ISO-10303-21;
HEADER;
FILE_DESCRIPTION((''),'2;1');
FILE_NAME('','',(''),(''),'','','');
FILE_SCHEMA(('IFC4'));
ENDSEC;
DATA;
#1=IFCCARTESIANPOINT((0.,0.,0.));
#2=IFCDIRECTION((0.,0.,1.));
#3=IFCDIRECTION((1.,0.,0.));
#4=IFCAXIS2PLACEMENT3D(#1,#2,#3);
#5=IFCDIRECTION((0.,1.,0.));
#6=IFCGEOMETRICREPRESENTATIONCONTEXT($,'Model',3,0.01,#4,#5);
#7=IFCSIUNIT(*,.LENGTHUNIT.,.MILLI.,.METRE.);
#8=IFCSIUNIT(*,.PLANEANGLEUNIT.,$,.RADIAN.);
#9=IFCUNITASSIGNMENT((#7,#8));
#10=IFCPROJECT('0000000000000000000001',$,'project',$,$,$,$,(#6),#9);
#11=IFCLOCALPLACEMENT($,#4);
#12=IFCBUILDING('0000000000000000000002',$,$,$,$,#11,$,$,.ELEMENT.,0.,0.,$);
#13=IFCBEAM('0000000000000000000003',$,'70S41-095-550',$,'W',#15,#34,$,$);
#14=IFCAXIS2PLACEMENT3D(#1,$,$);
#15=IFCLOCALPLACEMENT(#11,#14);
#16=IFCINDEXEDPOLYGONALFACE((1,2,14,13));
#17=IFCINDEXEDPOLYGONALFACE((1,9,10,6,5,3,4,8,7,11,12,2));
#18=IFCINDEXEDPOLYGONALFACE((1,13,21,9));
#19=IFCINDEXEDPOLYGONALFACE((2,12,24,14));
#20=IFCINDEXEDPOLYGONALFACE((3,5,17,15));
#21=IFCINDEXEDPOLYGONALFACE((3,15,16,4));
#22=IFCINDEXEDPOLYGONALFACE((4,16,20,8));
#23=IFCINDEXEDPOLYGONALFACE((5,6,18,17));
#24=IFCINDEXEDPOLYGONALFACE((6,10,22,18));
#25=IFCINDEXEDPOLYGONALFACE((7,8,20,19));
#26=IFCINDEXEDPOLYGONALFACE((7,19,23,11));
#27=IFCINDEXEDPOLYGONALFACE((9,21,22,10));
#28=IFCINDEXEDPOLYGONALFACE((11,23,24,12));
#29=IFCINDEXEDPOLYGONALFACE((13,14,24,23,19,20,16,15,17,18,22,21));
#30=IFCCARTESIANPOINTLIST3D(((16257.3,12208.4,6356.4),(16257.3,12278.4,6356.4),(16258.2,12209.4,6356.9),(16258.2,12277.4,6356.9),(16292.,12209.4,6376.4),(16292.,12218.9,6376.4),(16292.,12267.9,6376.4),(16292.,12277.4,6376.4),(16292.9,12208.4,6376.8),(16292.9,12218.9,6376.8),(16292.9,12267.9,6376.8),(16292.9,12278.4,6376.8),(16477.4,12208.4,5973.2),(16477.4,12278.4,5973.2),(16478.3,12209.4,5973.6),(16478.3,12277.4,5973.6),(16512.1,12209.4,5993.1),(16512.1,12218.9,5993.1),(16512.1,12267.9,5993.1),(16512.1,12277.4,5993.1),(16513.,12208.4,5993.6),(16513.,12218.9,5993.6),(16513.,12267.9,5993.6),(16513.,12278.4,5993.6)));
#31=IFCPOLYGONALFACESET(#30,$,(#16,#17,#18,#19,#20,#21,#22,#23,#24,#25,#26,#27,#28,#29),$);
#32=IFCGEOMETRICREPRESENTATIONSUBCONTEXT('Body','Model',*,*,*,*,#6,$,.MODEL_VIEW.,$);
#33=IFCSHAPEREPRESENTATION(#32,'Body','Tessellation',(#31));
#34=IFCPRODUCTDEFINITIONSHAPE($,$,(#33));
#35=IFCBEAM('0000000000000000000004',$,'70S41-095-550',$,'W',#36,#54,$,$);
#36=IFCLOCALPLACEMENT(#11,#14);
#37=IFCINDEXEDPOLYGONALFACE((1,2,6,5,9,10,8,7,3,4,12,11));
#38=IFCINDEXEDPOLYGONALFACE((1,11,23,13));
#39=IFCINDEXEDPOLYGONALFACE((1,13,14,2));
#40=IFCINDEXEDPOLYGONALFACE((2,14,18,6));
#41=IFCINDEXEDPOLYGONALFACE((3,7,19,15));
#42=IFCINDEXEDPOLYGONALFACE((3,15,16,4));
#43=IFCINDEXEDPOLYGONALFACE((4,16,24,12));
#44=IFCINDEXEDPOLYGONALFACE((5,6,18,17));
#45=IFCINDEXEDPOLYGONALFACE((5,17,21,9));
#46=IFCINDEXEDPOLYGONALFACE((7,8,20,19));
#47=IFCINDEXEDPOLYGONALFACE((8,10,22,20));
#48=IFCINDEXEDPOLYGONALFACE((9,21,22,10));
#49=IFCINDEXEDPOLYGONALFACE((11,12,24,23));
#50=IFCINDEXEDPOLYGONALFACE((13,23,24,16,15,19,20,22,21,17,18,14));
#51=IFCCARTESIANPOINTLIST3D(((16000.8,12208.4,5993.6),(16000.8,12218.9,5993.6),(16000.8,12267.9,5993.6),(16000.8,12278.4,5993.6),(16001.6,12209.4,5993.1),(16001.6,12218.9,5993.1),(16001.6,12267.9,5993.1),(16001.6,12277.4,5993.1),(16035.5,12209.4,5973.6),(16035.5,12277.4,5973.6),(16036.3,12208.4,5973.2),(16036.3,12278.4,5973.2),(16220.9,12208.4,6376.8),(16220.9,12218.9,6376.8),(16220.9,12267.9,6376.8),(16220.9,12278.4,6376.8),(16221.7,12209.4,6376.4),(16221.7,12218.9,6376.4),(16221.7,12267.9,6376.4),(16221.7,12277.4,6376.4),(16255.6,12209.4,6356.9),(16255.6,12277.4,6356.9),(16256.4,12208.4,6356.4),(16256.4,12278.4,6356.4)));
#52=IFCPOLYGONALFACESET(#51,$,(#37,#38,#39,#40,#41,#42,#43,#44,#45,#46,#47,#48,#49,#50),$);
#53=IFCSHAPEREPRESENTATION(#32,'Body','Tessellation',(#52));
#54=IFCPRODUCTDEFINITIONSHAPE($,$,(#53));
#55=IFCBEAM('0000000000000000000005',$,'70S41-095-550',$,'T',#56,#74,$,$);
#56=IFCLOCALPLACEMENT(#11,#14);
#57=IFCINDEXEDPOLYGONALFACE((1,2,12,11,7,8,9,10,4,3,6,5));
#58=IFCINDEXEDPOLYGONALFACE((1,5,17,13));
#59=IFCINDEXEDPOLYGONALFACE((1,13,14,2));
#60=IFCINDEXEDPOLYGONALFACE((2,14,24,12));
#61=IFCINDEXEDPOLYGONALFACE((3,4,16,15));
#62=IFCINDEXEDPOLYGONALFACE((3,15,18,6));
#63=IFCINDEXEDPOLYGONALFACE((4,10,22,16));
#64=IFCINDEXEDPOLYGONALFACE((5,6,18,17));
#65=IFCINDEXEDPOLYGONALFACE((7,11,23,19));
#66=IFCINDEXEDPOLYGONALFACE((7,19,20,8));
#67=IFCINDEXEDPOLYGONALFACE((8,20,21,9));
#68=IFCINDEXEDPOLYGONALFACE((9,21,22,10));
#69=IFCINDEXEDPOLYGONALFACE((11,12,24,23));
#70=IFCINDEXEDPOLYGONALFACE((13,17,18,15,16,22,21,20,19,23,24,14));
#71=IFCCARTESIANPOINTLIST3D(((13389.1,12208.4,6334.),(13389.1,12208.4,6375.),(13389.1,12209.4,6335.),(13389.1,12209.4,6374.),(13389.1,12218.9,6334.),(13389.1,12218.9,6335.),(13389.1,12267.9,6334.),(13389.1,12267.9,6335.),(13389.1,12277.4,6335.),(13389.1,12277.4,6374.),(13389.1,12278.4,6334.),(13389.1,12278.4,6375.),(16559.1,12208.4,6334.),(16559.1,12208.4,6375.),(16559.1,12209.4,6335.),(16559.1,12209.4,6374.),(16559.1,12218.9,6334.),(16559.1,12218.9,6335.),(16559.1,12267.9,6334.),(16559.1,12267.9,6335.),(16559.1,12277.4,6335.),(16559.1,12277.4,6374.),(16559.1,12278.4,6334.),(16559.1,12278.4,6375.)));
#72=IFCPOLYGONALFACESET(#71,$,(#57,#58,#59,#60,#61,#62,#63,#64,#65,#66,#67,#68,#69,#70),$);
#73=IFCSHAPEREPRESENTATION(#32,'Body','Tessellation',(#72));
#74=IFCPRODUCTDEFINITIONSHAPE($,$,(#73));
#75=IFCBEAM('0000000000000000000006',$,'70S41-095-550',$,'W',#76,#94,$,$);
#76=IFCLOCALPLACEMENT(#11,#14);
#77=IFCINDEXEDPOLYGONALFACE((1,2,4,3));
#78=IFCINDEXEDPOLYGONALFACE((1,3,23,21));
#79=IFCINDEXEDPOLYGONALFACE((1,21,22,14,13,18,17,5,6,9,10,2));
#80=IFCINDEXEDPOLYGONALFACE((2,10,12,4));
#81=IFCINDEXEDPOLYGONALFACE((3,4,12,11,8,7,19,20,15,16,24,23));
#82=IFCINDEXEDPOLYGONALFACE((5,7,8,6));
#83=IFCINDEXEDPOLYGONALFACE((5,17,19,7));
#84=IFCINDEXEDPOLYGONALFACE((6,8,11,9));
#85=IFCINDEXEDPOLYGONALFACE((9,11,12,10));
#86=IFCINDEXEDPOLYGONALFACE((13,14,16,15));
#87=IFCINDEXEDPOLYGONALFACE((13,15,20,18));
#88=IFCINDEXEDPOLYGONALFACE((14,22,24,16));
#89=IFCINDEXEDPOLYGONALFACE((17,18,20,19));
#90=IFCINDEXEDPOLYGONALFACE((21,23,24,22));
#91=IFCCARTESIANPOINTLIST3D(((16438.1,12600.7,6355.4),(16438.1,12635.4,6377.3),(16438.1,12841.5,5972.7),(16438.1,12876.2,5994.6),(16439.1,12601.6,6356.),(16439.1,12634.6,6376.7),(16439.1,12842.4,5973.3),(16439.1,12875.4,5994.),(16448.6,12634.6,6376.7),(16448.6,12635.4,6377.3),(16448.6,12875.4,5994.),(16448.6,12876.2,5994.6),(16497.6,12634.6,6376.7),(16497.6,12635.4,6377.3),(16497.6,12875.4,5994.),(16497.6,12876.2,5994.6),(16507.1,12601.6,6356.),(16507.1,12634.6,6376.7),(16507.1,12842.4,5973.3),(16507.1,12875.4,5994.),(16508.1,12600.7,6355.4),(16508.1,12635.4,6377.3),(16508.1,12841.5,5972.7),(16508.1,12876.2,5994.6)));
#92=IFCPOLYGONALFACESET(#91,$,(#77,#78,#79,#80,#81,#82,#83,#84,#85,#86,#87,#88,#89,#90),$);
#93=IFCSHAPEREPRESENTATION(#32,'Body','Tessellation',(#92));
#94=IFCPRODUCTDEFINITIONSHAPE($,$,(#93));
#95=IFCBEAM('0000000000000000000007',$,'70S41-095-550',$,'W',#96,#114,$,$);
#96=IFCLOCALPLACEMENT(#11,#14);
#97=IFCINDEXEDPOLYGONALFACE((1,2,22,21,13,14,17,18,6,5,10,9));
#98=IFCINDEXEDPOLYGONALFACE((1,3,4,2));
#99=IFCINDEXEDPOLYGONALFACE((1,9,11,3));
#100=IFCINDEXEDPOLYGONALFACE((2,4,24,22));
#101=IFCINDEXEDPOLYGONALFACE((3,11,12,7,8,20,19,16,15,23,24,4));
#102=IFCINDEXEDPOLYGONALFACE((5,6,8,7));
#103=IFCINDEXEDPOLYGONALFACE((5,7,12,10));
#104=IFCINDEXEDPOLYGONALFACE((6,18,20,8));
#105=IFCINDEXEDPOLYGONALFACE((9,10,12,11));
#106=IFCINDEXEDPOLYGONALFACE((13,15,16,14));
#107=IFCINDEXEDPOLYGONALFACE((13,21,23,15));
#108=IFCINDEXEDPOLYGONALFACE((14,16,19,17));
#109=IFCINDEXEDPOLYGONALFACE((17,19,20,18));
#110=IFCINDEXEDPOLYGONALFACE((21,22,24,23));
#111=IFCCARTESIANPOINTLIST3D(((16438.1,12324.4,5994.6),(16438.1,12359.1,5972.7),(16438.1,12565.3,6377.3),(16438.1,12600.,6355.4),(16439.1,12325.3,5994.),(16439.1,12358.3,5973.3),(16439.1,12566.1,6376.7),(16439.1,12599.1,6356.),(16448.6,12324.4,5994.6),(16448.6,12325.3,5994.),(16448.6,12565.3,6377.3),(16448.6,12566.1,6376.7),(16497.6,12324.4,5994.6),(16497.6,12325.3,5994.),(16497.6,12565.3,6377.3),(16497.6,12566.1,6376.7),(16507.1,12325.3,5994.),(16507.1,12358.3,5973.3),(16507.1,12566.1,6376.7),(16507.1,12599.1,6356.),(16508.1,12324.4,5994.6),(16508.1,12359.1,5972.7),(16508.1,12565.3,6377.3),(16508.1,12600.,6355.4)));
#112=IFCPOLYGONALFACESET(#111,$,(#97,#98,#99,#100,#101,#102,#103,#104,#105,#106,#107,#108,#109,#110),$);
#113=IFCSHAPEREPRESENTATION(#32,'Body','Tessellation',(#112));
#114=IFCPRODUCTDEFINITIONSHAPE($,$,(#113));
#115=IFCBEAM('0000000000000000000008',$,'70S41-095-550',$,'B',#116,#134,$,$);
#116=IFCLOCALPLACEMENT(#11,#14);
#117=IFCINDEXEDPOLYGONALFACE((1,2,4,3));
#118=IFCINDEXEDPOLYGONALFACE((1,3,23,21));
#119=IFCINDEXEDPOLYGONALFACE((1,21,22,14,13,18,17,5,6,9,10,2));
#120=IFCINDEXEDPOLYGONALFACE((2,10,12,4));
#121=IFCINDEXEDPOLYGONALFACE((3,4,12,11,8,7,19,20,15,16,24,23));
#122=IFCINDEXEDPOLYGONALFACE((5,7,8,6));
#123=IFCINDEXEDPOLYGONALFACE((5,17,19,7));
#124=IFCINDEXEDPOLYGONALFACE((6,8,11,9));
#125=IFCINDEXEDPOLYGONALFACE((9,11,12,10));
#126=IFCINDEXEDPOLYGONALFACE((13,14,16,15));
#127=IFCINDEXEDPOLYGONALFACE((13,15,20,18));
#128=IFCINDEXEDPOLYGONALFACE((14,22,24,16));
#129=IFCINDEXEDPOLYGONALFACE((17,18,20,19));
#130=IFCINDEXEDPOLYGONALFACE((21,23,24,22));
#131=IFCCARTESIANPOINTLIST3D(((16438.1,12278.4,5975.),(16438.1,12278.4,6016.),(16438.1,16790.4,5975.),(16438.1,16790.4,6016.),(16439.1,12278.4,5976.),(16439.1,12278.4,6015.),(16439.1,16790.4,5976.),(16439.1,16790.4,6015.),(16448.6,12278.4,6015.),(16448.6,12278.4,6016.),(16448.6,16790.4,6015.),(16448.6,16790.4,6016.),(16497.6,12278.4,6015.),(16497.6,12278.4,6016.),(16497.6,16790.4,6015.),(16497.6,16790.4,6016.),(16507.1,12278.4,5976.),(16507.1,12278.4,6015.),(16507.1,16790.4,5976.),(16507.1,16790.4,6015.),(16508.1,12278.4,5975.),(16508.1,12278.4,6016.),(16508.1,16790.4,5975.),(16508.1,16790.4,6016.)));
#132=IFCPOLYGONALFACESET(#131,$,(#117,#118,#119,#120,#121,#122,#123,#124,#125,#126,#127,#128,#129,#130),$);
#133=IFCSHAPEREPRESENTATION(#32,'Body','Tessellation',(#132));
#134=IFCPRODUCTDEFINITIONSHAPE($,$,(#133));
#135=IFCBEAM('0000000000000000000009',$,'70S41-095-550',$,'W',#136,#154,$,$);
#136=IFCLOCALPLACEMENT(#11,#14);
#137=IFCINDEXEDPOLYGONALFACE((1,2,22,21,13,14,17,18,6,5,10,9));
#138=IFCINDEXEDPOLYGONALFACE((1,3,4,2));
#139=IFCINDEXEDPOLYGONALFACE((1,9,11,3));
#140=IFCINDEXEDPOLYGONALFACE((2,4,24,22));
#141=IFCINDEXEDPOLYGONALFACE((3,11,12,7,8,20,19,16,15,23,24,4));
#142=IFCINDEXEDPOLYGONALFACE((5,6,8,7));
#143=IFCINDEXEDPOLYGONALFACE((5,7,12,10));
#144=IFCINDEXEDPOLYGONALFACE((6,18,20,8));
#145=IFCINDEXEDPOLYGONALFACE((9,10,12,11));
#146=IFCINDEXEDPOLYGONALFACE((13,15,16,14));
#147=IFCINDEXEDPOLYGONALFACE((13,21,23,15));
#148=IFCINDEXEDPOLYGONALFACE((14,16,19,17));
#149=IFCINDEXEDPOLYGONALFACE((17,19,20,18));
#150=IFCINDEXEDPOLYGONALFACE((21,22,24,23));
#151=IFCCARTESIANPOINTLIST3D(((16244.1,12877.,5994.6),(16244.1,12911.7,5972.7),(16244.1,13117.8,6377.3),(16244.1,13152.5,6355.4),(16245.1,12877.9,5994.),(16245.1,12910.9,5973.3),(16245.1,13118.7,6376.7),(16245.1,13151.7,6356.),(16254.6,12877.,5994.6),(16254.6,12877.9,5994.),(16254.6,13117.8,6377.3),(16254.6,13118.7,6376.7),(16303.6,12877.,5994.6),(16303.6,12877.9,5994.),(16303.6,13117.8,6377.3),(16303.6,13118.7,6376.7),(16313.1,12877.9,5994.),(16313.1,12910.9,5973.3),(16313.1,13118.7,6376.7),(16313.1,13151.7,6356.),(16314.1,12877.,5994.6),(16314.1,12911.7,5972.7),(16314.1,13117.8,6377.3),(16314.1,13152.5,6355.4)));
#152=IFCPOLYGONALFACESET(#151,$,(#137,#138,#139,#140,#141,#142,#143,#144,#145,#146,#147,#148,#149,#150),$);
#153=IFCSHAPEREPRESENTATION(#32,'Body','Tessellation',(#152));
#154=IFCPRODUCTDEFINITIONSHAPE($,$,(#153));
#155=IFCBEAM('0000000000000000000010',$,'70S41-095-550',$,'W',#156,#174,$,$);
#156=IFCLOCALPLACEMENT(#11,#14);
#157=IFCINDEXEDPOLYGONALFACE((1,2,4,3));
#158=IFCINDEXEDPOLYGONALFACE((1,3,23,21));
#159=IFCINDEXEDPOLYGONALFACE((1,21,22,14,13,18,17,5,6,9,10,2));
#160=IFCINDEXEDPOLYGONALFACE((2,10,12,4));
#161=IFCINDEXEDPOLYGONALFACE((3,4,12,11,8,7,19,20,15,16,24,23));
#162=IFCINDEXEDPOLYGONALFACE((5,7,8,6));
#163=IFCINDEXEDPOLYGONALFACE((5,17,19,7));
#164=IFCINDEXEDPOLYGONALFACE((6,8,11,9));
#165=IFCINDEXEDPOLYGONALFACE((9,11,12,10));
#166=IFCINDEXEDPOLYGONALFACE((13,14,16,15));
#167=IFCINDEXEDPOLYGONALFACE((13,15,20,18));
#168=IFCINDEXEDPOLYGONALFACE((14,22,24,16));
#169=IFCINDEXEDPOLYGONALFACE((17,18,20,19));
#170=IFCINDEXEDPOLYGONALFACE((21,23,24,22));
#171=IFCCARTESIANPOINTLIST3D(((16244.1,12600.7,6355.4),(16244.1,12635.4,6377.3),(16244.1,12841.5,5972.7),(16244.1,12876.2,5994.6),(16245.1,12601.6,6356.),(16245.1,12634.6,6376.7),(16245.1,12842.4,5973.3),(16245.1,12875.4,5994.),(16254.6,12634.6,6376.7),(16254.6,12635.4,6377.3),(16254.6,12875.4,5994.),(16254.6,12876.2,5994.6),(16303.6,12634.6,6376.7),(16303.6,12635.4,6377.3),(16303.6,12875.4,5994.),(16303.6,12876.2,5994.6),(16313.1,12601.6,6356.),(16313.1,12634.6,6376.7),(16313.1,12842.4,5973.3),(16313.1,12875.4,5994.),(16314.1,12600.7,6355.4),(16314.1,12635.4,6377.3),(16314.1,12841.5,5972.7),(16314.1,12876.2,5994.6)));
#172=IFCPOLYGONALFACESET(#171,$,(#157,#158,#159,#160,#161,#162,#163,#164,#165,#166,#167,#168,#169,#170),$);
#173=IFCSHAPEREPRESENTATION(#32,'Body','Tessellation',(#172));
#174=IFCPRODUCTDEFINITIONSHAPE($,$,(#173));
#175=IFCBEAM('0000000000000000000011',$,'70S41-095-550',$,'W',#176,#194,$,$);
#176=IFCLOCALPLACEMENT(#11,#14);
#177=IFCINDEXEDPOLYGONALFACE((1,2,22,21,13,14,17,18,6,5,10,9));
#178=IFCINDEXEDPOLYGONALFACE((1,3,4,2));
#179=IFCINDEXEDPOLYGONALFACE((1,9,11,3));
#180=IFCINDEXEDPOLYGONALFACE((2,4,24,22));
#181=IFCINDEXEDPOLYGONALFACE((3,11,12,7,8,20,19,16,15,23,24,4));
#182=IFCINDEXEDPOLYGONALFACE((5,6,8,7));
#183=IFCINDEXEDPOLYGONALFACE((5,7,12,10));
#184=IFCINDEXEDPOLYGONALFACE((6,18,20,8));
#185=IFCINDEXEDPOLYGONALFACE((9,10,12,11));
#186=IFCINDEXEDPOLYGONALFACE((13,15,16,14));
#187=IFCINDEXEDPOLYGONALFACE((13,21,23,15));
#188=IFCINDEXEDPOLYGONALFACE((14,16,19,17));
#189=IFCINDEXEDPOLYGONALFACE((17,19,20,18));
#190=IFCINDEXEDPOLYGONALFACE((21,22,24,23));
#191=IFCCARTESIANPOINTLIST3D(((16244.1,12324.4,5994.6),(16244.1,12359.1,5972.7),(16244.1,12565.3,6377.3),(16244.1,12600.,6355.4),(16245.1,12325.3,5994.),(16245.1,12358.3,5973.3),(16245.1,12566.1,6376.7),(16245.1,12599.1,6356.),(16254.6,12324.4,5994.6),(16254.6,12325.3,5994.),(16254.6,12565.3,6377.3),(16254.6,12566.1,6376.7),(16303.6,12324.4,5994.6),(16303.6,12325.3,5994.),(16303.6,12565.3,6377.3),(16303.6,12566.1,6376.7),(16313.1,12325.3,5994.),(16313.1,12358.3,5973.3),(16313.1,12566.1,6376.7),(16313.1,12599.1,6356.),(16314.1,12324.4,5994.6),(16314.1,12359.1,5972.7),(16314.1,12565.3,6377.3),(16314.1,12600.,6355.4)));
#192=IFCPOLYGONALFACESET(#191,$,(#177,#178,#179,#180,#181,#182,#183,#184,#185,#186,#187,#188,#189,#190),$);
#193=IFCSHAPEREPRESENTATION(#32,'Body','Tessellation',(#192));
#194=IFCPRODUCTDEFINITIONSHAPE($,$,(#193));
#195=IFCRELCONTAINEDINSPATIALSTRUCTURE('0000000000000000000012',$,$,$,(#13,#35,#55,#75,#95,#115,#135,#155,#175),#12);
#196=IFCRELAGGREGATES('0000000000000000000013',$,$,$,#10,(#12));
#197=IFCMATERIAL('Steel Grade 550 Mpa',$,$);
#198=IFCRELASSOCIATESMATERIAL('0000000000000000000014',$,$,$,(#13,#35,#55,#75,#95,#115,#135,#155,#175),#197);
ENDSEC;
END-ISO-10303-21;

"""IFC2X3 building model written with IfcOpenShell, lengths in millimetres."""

from ifc_helpers import new_model, si_unit, direction, frame, origin, origin_with_axes, origin_2d_with_axis, place, context, subcontext, project, spatial, c_section, extrude, source, transform, mapped, material, element, save


model = new_model("IFC2X3")

# Units and contexts
model_context = context("Model", 3, precision=0.01, world=origin_with_axes(), true_north=direction((0.0, 1.0, 0.0)))
body_context = subcontext(model_context, "Body", "Model", "MODEL_VIEW")
ifc_project = project(units=[si_unit("LENGTHUNIT", "METRE", prefix="MILLI"), si_unit("PLANEANGLEUNIT", "RADIAN")], contexts=[model_context])

# Building
building_placement = place(None, origin_with_axes())
building = spatial("IfcBuilding", under=ifc_project, at=building_placement, CompositionType="ELEMENT", ElevationOfRefHeight=0.0, ElevationOfTerrain=0.0)

# Shared definitions
ifc_material = material(Name="Steel Grade 550 Mpa")

# Beams
shared_shape_1 = source(origin(), body_context, "Body", "SweptSolid", [
    extrude(c_section(Depth=70.0, Width=41.0, WallThickness=1.0, Girth=10.5, at=origin_2d_with_axis()), origin_with_axes(), (0.0, 0.0, 1.0), 442.0),
])
beam_1_placement = place(None, frame((16275.1, 12243.4, 6366.6), z_axis=(0.497993, 0.0, -0.867181), x_axis=(0.867181, 0.0, 0.497993)))
element("IfcBeam", 1, at=beam_1_placement, inside=building, material=ifc_material, Name="70S41-095-550", ObjectType="W", context=body_context, shape_type="MappedRepresentation", body=[
    mapped(shared_shape_1, transform((0.0, 0.0, 0.0), scale=1.0)),
])
shared_shape_2 = source(origin(), body_context, "Body", "SweptSolid", [
    extrude(c_section(Depth=70.0, Width=41.0, WallThickness=1.0, Girth=10.5, at=origin_2d_with_axis()), origin_with_axes(), (0.0, 0.0, 1.0), 442.0),
])
beam_2_placement = place(None, frame((16018.5, 12243.4, 5983.4), z_axis=(0.497993, 0.0, 0.867181), x_axis=(-0.867181, 0.0, 0.497993)))
element("IfcBeam", 2, at=beam_2_placement, inside=building, material=ifc_material, Name="70S41-095-550", ObjectType="W", context=body_context, shape_type="MappedRepresentation", body=[
    mapped(shared_shape_2, transform((0.0, 0.0, 0.0), scale=1.0)),
])
shared_shape_3 = source(origin(), body_context, "Body", "SweptSolid", [
    extrude(c_section(Depth=70.0, Width=41.0, WallThickness=1.0, Girth=10.5, at=origin_2d_with_axis()), origin_with_axes(), (0.0, 0.0, 1.0), 3170.0),
])
beam_3_placement = place(None, frame((16559.1, 12243.4, 6354.5), z_axis=(-1.0, 0.0, 0.0), x_axis=(0.0, 0.0, -1.0)))
element("IfcBeam", 3, at=beam_3_placement, inside=building, material=ifc_material, Name="70S41-095-550", ObjectType="T", context=body_context, shape_type="MappedRepresentation", body=[
    mapped(shared_shape_3, transform((0.0, 0.0, 0.0), scale=1.0)),
])
shared_shape_4 = source(origin(), body_context, "Body", "SweptSolid", [
    extrude(c_section(Depth=70.0, Width=41.0, WallThickness=1.0, Girth=10.5, at=origin_2d_with_axis()), origin_with_axes(), (0.0, 0.0, 1.0), 452.2),
])
beam_4_placement = place(None, frame((16473.1, 12618.1, 6366.3), z_axis=(0.0, 0.532581, -0.846379), x_axis=(0.0, 0.846379, 0.532581)))
element("IfcBeam", 4, at=beam_4_placement, inside=building, material=ifc_material, Name="70S41-095-550", ObjectType="W", context=body_context, shape_type="MappedRepresentation", body=[
    mapped(shared_shape_4, transform((0.0, 0.0, 0.0), scale=1.0)),
])
shared_shape_5 = source(origin(), body_context, "Body", "SweptSolid", [
    extrude(c_section(Depth=70.0, Width=41.0, WallThickness=1.0, Girth=10.5, at=origin_2d_with_axis()), origin_with_axes(), (0.0, 0.0, 1.0), 452.2),
])
beam_5_placement = place(None, frame((16473.1, 12341.8, 5983.7), z_axis=(0.0, 0.532581, 0.846379), x_axis=(0.0, -0.846379, 0.532581)))
element("IfcBeam", 5, at=beam_5_placement, inside=building, material=ifc_material, Name="70S41-095-550", ObjectType="W", context=body_context, shape_type="MappedRepresentation", body=[
    mapped(shared_shape_5, transform((0.0, 0.0, 0.0), scale=1.0)),
])
shared_shape_6 = source(origin(), body_context, "Body", "SweptSolid", [
    extrude(c_section(Depth=70.0, Width=41.0, WallThickness=1.0, Girth=10.5, at=origin_2d_with_axis()), origin_with_axes(), (0.0, 0.0, 1.0), 4512.0),
])
beam_6_placement = place(None, frame((16473.1, 12278.4, 5995.5), z_axis=(0.0, 1.0, 0.0), x_axis=(0.0, 0.0, 1.0)))
element("IfcBeam", 6, at=beam_6_placement, inside=building, material=ifc_material, Name="70S41-095-550", ObjectType="B", context=body_context, shape_type="MappedRepresentation", body=[
    mapped(shared_shape_6, transform((0.0, 0.0, 0.0), scale=1.0)),
])
shared_shape_7 = source(origin(), body_context, "Body", "SweptSolid", [
    extrude(c_section(Depth=70.0, Width=41.0, WallThickness=1.0, Girth=10.5, at=origin_2d_with_axis()), origin_with_axes(), (0.0, 0.0, 1.0), 452.2),
])
beam_7_placement = place(None, frame((16279.1, 12894.4, 5983.7), z_axis=(0.0, 0.532581, 0.846379), x_axis=(0.0, -0.846379, 0.532581)))
element("IfcBeam", 7, at=beam_7_placement, inside=building, material=ifc_material, Name="70S41-095-550", ObjectType="W", context=body_context, shape_type="MappedRepresentation", body=[
    mapped(shared_shape_7, transform((0.0, 0.0, 0.0), scale=1.0)),
])
shared_shape_8 = source(origin(), body_context, "Body", "SweptSolid", [
    extrude(c_section(Depth=70.0, Width=41.0, WallThickness=1.0, Girth=10.5, at=origin_2d_with_axis()), origin_with_axes(), (0.0, 0.0, 1.0), 452.2),
])
beam_8_placement = place(None, frame((16279.1, 12618.1, 6366.3), z_axis=(0.0, 0.532581, -0.846379), x_axis=(0.0, 0.846379, 0.532581)))
element("IfcBeam", 8, at=beam_8_placement, inside=building, material=ifc_material, Name="70S41-095-550", ObjectType="W", context=body_context, shape_type="MappedRepresentation", body=[
    mapped(shared_shape_8, transform((0.0, 0.0, 0.0), scale=1.0)),
])
shared_shape_9 = source(origin(), body_context, "Body", "SweptSolid", [
    extrude(c_section(Depth=70.0, Width=41.0, WallThickness=1.0, Girth=10.5, at=origin_2d_with_axis()), origin_with_axes(), (0.0, 0.0, 1.0), 452.2),
])
beam_9_placement = place(None, frame((16279.1, 12341.8, 5983.7), z_axis=(0.0, 0.532581, 0.846379), x_axis=(0.0, -0.846379, 0.532581)))
element("IfcBeam", 9, at=beam_9_placement, inside=building, material=ifc_material, Name="70S41-095-550", ObjectType="W", context=body_context, shape_type="MappedRepresentation", body=[
    mapped(shared_shape_9, transform((0.0, 0.0, 0.0), scale=1.0)),
])

save(model, "model.ifc")
